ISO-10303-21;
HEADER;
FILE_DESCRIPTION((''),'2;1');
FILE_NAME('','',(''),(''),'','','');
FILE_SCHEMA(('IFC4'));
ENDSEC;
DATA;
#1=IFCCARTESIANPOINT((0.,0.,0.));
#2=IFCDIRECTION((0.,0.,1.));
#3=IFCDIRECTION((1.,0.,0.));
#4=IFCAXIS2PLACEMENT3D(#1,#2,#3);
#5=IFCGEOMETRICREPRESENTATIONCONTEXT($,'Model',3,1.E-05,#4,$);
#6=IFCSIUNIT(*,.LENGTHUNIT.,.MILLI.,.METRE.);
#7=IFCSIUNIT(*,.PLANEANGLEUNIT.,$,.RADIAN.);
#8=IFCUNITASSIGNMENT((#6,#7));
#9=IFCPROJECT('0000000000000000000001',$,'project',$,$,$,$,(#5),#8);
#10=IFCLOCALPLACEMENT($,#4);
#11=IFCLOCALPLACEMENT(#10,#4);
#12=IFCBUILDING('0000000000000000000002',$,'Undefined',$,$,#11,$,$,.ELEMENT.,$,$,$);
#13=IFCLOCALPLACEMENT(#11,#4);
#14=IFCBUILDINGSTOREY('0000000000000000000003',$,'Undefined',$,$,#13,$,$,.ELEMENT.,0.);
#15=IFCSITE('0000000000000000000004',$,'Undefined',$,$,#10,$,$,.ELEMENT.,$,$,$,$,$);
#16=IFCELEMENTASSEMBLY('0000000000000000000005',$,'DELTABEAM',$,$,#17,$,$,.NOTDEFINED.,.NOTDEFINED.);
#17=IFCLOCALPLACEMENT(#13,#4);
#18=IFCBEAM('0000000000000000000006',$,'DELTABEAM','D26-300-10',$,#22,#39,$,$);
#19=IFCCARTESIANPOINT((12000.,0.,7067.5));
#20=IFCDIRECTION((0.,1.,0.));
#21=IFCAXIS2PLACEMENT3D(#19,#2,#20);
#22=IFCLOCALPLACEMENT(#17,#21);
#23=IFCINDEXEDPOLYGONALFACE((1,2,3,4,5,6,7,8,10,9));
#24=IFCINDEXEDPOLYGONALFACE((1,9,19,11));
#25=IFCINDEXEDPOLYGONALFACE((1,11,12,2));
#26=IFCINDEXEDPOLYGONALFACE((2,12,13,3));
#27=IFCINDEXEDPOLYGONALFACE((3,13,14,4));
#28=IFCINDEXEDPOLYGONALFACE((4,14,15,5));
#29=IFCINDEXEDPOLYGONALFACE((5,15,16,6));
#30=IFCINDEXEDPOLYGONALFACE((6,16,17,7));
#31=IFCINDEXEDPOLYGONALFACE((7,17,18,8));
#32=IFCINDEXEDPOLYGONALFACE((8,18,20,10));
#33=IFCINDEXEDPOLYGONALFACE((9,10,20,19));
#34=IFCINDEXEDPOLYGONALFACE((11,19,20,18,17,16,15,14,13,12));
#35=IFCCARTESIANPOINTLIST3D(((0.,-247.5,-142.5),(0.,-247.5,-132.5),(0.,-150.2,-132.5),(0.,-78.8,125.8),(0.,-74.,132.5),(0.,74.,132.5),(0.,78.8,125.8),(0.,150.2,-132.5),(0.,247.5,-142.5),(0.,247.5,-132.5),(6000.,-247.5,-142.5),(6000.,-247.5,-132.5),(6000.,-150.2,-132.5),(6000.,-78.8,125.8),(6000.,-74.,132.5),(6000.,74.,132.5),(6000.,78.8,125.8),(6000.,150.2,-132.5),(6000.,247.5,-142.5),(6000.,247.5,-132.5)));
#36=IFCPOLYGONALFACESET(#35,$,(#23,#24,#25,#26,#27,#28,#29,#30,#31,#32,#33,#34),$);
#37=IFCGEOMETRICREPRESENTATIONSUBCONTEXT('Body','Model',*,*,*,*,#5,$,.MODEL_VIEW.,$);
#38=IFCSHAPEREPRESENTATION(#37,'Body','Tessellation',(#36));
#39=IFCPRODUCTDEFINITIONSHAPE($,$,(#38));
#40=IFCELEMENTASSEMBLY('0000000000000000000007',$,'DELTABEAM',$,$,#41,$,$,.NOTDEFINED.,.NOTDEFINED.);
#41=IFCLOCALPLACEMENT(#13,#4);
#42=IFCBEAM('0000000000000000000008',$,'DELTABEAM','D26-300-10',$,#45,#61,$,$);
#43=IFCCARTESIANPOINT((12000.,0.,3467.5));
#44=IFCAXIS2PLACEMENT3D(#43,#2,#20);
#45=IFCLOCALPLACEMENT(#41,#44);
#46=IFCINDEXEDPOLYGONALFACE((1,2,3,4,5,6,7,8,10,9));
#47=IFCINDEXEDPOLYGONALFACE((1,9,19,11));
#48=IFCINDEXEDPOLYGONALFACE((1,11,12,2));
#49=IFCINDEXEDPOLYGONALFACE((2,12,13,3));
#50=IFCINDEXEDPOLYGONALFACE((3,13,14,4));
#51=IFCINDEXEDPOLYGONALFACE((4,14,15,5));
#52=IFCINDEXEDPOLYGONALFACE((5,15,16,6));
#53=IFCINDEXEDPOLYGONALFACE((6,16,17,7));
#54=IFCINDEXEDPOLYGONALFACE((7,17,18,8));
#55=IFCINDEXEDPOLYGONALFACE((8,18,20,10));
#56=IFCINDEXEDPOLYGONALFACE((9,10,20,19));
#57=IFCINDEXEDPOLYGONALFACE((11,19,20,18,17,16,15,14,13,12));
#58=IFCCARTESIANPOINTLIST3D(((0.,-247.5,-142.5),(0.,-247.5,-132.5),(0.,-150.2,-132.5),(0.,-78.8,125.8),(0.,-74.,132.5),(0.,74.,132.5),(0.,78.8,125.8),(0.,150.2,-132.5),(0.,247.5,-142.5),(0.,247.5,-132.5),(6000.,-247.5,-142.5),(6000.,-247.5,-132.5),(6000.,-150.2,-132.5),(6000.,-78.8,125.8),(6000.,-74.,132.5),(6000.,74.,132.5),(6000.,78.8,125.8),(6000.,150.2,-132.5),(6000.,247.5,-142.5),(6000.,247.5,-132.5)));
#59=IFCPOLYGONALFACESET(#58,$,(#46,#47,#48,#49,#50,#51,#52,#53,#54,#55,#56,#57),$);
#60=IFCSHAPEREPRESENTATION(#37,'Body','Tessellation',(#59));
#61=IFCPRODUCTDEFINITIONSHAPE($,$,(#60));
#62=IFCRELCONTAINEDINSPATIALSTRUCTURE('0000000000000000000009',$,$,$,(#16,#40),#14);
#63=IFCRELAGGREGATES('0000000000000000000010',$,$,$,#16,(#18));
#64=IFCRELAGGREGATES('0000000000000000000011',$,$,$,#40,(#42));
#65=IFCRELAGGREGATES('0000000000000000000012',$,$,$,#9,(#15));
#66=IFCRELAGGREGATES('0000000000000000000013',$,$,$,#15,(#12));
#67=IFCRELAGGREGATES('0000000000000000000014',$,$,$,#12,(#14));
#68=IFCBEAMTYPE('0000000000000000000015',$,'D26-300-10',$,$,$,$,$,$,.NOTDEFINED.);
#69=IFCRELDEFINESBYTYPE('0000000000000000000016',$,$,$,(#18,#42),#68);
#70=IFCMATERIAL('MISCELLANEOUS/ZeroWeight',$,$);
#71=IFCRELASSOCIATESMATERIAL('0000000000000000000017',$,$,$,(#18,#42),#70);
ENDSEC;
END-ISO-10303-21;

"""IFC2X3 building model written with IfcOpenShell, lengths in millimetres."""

from ifc_helpers import new_model, si_unit, frame, origin_with_axes, place, context, subcontext, project, spatial, polyline, outline, extrude, material, type_object, element, aggregate, save


model = new_model("IFC2X3")

# Units and contexts
model_context = context("Model", 3, precision=1e-05, world=origin_with_axes())
body_context = subcontext(model_context, "Body", "Model", "MODEL_VIEW")
ifc_project = project(units=[si_unit("LENGTHUNIT", "METRE", prefix="MILLI"), si_unit("PLANEANGLEUNIT", "RADIAN")], contexts=[model_context])

# Site, building, storey
site_placement = place(None, origin_with_axes())
site = spatial("IfcSite", under=ifc_project, at=site_placement, Name="Undefined", CompositionType="ELEMENT")
building_placement = place(site_placement, origin_with_axes())
building = spatial("IfcBuilding", under=site, at=building_placement, Name="Undefined", CompositionType="ELEMENT")
storey_placement = place(building_placement, origin_with_axes())
storey = spatial("IfcBuildingStorey", under=building, at=storey_placement, Name="Undefined", CompositionType="ELEMENT", Elevation=0.0)

# Element assemblies, beams
assembly_1_placement = place(storey_placement, origin_with_axes())
assembly_1 = element("IfcElementAssembly", 1, at=assembly_1_placement, inside=storey, Name="DELTABEAM", AssemblyPlace="NOTDEFINED", PredefinedType="NOTDEFINED")
ifc_material_1 = material(Name="MISCELLANEOUS/ZeroWeight")
beam_type = type_object("IfcBeamType", Name="D26-300-10", PredefinedType="NOTDEFINED")
beam_1_placement = place(assembly_1_placement, frame((12000.0, 0.0, 7067.5), z_axis=(0.0, 0.0, 1.0), x_axis=(0.0, 1.0, 0.0)))
beam_1 = element("IfcBeam", 2, at=beam_1_placement, type_object=beam_type, material=ifc_material_1, Name="DELTABEAM", Description="D26-300-10", context=body_context, shape_type="SweptSolid", body=[
    extrude(outline(polyline([(-75.1, 120.5), (-145.0, -132.5), (247.5, -132.5), (247.5, -142.5), (-247.5, -142.5), (-247.5, -132.5), (-150.2, -132.5), (-78.8, 125.8), (-74.0, 132.5), (74.0, 132.5), (78.8, 125.8), (150.2, -132.5), (145.0, -132.5), (75.1, 120.5), (-75.1, 120.5)])), frame((6000.0, 0.0, 0.0), z_axis=(-1.0, 0.0, 0.0), x_axis=(0.0, -1.0, 0.0)), (0.0, 0.0, 1.0), 6000.0),
])
aggregate(assembly_1, [beam_1])
assembly_2_placement = place(storey_placement, origin_with_axes())
assembly_2 = element("IfcElementAssembly", 3, at=assembly_2_placement, inside=storey, Name="DELTABEAM", AssemblyPlace="NOTDEFINED", PredefinedType="NOTDEFINED")
beam_2_placement = place(assembly_2_placement, frame((12000.0, 0.0, 3467.5), z_axis=(0.0, 0.0, 1.0), x_axis=(0.0, 1.0, 0.0)))
beam_2 = element("IfcBeam", 4, at=beam_2_placement, type_object=beam_type, material=ifc_material_1, Name="DELTABEAM", Description="D26-300-10", context=body_context, shape_type="SweptSolid", body=[
    extrude(outline(polyline([(-75.1, 120.5), (-145.0, -132.5), (247.5, -132.5), (247.5, -142.5), (-247.5, -142.5), (-247.5, -132.5), (-150.2, -132.5), (-78.8, 125.8), (-74.0, 132.5), (74.0, 132.5), (78.8, 125.8), (150.2, -132.5), (145.0, -132.5), (75.1, 120.5), (-75.1, 120.5)])), frame((6000.0, 0.0, 0.0), z_axis=(-1.0, 0.0, 0.0), x_axis=(0.0, -1.0, 0.0)), (0.0, 0.0, 1.0), 6000.0),
])
aggregate(assembly_2, [beam_2])

save(model, "model.ifc")
